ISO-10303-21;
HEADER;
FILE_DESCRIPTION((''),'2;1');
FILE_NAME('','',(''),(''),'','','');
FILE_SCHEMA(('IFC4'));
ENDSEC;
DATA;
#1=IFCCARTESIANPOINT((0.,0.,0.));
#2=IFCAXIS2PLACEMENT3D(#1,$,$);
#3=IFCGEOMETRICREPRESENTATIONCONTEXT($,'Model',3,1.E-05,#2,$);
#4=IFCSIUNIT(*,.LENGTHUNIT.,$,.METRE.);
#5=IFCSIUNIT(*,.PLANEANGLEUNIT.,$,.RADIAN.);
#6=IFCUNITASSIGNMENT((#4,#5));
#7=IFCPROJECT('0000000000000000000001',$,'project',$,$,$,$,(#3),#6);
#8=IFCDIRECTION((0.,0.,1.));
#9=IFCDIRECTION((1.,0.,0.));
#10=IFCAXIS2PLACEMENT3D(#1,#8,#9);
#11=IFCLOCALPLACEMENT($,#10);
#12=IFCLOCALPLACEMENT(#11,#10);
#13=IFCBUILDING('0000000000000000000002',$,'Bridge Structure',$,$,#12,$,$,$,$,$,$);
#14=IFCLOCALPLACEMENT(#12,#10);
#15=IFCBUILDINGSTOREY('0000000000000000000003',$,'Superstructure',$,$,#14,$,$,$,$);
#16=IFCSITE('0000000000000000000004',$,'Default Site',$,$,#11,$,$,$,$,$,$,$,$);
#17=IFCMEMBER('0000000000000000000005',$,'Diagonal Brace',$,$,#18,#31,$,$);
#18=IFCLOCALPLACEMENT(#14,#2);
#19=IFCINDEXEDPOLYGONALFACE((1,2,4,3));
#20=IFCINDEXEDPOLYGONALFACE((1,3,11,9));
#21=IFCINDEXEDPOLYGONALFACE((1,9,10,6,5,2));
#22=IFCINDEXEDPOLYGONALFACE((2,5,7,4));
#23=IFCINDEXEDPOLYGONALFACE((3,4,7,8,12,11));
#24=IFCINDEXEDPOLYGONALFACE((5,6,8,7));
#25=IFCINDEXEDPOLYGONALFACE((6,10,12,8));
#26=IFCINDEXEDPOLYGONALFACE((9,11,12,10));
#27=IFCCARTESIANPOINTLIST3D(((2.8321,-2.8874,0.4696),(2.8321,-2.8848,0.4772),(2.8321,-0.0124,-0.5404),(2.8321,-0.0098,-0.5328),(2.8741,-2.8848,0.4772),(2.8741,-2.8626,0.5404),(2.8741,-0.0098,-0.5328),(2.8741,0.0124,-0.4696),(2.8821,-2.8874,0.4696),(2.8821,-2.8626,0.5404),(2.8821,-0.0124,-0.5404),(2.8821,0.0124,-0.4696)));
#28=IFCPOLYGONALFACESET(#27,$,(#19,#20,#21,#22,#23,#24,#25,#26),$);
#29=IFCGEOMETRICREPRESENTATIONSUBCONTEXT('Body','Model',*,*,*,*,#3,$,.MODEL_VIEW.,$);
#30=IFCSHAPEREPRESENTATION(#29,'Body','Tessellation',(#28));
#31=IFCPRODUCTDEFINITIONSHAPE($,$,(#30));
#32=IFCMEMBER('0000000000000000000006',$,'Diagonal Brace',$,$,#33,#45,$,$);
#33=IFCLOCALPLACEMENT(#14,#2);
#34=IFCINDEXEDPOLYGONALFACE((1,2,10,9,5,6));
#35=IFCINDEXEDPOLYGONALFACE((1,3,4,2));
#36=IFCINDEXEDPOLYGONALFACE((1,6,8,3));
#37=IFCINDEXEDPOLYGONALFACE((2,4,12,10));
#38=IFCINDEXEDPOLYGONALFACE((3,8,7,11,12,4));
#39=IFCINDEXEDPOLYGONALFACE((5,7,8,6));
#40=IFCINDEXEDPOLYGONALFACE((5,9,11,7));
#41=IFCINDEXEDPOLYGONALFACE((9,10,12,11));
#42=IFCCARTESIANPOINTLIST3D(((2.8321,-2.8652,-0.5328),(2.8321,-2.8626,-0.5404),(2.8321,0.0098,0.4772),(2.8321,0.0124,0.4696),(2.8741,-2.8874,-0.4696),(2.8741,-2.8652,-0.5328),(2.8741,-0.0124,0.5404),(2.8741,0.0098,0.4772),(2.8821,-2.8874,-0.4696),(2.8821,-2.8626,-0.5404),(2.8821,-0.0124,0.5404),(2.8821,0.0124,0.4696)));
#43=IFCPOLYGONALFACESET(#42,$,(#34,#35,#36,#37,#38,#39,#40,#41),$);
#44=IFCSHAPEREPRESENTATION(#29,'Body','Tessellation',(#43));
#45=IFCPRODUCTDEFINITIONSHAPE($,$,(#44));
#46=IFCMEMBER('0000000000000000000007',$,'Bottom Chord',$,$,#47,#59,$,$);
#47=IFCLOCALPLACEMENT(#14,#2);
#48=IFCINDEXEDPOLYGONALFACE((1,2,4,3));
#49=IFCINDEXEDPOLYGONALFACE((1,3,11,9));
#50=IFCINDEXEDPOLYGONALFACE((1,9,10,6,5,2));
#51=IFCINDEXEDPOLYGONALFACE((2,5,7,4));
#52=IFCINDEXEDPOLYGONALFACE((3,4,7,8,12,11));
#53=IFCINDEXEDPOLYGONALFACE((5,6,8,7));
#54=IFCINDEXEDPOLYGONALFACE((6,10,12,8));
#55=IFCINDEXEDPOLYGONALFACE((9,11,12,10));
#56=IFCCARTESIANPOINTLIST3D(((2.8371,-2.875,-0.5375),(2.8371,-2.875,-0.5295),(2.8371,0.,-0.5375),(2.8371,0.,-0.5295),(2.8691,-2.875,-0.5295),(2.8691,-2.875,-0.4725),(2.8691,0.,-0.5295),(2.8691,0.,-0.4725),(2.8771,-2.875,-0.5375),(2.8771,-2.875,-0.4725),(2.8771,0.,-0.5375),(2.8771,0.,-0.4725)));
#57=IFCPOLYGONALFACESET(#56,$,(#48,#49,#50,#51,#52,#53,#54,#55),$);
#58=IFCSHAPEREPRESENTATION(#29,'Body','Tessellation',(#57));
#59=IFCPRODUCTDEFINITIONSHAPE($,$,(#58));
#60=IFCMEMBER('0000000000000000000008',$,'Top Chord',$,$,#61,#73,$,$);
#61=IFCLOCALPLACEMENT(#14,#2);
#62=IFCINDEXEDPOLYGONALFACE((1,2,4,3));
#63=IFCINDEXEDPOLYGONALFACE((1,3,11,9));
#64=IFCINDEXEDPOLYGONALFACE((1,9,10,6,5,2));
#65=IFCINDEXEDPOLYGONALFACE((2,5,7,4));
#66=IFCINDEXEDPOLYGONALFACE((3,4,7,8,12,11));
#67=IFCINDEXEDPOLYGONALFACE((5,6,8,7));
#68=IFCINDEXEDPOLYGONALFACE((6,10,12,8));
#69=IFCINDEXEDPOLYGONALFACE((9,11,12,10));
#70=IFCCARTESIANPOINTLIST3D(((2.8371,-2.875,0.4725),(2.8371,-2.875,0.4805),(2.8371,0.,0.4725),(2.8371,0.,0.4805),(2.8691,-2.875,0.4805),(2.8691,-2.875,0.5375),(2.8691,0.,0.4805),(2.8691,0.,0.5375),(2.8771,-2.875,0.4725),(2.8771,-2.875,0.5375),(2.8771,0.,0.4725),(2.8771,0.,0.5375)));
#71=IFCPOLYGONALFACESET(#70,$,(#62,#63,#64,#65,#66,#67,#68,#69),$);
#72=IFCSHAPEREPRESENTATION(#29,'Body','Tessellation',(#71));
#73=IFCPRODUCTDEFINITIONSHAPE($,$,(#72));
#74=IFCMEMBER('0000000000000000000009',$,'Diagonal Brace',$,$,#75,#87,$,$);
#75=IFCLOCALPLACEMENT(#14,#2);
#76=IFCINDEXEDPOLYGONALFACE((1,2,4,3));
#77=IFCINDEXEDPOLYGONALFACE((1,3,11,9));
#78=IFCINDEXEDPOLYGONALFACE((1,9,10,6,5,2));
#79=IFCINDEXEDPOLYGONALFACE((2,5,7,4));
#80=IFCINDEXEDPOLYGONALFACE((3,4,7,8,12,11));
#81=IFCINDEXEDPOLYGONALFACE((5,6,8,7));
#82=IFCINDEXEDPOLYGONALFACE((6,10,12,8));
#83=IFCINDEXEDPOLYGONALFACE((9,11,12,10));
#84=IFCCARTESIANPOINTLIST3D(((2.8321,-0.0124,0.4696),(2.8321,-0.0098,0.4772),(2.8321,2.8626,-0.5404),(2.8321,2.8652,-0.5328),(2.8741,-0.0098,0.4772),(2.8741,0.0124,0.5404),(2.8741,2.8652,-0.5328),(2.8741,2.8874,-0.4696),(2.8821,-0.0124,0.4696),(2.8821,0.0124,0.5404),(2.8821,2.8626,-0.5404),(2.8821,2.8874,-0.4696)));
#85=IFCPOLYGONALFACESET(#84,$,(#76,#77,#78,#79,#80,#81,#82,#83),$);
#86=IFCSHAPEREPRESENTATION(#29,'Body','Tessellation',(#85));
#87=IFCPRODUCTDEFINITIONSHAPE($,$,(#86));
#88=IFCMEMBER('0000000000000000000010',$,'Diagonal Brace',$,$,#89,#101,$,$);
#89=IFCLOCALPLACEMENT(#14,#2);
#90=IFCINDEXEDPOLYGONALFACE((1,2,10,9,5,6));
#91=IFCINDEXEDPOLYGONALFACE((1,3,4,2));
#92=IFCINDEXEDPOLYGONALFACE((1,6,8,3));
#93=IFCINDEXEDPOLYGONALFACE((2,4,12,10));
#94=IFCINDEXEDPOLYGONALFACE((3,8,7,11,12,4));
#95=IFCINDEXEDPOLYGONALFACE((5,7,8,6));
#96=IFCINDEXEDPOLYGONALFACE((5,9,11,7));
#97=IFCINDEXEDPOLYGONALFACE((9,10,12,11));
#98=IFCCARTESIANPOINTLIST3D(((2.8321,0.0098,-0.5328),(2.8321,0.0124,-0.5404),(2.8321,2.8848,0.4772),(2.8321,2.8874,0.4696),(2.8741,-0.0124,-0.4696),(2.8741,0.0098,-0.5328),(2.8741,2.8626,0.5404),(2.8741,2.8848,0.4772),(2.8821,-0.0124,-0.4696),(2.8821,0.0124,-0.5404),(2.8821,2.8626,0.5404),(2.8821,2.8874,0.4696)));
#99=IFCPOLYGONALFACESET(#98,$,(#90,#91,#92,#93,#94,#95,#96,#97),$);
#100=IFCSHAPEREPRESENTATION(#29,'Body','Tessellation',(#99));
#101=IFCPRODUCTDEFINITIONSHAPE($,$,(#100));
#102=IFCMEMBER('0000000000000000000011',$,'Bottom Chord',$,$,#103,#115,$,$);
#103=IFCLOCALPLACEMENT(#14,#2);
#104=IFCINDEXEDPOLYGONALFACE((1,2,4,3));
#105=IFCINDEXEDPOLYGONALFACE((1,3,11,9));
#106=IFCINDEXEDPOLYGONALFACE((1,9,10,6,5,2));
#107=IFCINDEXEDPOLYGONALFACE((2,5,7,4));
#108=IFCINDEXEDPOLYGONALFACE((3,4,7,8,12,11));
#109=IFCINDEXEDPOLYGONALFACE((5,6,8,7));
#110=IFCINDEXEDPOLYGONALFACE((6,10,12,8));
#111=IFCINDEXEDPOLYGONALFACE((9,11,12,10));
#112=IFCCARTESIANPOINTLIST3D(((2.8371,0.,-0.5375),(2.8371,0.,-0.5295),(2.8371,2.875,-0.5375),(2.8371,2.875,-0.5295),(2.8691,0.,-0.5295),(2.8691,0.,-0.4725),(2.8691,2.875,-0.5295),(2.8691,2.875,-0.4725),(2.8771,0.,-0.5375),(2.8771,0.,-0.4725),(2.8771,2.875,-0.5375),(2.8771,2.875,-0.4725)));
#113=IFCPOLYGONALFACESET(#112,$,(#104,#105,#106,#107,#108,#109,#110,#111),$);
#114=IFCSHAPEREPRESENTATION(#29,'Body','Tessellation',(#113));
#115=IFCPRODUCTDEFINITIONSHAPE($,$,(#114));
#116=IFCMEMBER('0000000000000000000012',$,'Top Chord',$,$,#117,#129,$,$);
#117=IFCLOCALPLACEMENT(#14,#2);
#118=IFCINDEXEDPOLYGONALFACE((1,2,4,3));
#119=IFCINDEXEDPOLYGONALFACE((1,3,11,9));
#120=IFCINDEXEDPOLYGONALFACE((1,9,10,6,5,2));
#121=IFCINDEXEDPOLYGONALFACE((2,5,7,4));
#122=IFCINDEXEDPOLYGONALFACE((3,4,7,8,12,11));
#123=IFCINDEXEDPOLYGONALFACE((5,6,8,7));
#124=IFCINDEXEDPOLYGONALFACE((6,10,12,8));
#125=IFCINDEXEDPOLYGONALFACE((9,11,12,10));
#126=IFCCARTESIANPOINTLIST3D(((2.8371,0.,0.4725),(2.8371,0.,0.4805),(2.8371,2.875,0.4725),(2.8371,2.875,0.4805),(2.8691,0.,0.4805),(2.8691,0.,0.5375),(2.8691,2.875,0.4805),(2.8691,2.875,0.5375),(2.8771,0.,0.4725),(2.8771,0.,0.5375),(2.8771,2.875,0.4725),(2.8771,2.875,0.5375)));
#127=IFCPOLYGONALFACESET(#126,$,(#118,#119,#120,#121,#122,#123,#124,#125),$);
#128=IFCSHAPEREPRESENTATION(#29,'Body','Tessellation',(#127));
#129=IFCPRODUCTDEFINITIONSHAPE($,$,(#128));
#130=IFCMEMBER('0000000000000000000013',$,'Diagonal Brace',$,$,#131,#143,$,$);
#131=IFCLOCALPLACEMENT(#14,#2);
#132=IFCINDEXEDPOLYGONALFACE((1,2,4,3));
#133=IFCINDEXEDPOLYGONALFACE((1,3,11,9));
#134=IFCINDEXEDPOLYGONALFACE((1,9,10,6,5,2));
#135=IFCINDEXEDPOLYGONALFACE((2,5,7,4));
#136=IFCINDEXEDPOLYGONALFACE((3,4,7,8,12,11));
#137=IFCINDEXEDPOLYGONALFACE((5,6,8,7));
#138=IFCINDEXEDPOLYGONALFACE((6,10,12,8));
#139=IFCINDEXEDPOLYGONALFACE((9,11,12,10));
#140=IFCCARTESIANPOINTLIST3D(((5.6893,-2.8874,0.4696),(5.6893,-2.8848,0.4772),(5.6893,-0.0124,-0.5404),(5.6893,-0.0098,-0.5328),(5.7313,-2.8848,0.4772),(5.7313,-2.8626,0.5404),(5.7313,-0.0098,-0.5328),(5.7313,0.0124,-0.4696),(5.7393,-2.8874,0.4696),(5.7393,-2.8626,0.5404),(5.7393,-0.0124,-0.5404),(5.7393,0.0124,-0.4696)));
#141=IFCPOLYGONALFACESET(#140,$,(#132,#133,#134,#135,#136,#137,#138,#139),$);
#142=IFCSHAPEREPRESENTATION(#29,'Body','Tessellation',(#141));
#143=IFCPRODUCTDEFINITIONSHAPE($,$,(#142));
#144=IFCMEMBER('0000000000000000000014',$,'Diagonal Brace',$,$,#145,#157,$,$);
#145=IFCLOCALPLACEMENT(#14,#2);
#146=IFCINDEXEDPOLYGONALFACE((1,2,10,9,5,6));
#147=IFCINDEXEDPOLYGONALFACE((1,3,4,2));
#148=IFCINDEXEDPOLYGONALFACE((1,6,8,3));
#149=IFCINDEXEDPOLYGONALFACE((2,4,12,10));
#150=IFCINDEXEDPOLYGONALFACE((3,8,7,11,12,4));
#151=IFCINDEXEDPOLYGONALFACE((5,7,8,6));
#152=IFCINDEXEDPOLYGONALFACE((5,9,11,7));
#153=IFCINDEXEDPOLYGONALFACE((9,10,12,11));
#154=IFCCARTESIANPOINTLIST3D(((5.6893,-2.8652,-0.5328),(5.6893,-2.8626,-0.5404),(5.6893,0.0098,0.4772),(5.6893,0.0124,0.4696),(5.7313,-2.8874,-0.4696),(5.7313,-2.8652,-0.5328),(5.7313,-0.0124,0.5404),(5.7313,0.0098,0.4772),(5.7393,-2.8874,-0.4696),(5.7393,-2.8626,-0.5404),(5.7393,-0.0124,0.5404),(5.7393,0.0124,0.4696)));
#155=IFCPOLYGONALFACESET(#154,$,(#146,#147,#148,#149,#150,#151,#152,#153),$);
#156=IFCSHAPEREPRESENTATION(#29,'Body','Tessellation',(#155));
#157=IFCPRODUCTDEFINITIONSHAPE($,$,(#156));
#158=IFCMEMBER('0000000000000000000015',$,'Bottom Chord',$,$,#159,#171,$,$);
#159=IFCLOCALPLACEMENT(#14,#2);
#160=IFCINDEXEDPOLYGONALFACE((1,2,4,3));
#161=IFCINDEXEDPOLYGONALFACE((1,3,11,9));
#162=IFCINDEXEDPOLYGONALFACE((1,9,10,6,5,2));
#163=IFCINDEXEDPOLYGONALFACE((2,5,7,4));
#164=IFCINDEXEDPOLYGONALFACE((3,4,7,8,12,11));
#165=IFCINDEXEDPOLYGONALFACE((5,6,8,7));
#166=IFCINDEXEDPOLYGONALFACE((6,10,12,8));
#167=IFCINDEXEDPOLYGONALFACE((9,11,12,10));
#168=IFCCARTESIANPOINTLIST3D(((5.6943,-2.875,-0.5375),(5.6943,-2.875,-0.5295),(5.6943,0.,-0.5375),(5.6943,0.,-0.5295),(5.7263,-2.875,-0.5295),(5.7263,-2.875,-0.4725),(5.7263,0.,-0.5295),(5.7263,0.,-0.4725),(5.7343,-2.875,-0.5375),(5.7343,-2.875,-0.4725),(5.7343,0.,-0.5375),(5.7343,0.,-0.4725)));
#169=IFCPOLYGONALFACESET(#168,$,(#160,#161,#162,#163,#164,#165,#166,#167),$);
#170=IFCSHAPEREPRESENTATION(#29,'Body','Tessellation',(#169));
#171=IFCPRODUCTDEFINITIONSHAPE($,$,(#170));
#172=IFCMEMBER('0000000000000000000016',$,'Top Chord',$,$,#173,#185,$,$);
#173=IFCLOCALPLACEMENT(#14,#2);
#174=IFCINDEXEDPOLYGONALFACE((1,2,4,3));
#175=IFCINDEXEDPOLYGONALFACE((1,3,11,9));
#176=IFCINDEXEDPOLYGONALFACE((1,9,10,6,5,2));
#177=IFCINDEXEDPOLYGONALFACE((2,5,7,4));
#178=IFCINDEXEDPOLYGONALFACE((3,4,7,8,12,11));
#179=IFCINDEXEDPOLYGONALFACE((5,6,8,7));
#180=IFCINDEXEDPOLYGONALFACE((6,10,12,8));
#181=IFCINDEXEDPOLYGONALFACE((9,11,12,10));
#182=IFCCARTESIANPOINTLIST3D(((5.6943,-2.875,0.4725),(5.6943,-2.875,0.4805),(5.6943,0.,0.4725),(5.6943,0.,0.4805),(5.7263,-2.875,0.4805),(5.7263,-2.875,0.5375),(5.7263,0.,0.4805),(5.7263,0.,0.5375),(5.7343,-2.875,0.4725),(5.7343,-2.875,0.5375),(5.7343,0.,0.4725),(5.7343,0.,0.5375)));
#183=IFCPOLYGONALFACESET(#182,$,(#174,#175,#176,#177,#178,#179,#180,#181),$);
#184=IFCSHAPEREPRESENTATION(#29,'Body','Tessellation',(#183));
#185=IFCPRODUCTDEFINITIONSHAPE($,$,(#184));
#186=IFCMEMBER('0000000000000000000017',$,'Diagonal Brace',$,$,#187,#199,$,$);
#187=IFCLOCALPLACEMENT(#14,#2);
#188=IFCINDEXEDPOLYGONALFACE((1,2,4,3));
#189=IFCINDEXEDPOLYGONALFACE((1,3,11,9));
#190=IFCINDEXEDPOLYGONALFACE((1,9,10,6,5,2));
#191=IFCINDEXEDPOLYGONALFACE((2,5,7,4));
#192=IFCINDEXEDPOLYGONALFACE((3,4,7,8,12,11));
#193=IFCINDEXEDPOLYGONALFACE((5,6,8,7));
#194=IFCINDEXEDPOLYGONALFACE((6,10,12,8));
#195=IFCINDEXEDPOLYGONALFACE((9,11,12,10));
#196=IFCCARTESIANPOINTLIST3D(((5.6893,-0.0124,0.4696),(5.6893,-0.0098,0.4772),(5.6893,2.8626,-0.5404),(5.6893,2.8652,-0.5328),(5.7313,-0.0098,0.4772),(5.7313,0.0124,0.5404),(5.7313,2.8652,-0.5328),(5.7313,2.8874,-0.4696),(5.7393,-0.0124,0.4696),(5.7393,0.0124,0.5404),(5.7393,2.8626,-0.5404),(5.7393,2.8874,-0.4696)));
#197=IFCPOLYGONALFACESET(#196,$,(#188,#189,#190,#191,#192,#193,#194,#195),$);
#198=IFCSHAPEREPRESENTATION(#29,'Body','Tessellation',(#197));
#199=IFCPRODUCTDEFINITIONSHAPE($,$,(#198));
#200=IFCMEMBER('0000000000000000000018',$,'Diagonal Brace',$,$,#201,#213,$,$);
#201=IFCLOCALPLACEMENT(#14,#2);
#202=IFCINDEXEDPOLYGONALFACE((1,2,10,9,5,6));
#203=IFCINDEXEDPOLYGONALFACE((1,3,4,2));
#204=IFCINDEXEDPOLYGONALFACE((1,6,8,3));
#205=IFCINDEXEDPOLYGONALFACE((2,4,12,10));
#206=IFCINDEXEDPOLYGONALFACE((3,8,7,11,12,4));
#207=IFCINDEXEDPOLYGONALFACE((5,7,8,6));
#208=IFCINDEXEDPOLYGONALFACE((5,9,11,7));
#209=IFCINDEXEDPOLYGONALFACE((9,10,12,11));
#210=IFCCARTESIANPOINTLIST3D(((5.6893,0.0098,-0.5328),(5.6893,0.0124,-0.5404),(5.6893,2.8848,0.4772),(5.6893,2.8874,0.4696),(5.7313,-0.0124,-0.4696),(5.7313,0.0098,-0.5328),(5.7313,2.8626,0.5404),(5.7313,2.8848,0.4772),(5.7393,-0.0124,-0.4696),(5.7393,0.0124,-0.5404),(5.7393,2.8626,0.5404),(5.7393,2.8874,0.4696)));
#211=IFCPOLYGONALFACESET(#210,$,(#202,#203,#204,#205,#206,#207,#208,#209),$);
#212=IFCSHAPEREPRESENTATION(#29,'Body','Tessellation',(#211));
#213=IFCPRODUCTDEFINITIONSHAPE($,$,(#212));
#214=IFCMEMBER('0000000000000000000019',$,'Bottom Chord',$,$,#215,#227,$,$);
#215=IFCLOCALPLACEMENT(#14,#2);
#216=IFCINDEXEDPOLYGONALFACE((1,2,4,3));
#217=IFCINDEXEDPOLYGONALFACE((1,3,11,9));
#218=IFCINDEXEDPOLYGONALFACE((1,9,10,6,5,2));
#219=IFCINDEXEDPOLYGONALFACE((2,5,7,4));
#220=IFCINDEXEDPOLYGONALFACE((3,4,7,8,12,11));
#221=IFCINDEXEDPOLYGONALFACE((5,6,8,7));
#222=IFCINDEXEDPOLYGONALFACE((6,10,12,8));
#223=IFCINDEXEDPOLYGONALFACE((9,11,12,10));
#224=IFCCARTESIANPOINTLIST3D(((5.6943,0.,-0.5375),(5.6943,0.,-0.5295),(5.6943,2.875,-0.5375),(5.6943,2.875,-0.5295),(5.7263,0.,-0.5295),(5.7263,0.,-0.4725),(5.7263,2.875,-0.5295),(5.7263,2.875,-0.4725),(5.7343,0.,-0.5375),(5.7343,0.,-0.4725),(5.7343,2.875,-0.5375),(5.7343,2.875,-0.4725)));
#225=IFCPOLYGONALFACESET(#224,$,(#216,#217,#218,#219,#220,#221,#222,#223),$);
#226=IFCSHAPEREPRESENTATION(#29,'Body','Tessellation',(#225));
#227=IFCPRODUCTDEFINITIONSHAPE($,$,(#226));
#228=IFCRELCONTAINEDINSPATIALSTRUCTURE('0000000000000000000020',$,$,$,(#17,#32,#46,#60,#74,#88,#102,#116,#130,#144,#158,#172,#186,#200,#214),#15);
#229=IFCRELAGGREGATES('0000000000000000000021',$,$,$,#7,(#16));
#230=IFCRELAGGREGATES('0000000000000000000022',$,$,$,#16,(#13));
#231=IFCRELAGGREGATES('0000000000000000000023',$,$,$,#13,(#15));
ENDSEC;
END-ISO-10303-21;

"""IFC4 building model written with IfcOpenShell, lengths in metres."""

from ifc_helpers import new_model, si_unit, frame, origin, origin_with_axes, origin_2d_with_axis, place, context, subcontext, project, spatial, l_section, extrude, element, save


model = new_model("IFC4")

# Units and contexts
model_context = context("Model", 3, precision=1e-05, world=origin())
body_context = subcontext(model_context, "Body", "Model", "MODEL_VIEW")
ifc_project = project(units=[si_unit("LENGTHUNIT", "METRE"), si_unit("PLANEANGLEUNIT", "RADIAN")], contexts=[model_context])

# Site, building, storey
site_placement = place(None, origin_with_axes())
site = spatial("IfcSite", under=ifc_project, at=site_placement, Name="Default Site")
building_placement = place(site_placement, origin_with_axes())
building = spatial("IfcBuilding", under=site, at=building_placement, Name="Bridge Structure")
storey_placement = place(building_placement, origin_with_axes())
storey = spatial("IfcBuildingStorey", under=building, at=storey_placement, Name="Superstructure")

# Members
for number, where, z_axis, x_axis, name in (
    (1, (2.8571, -2.875, 0.505), (0.0, 0.943474, -0.331447), (-1.0, 0.0, 0.0), "Diagonal Brace"),
    (2, (2.8571, -2.875, -0.505), (0.0, 0.943474, 0.331447), (-1.0, 0.0, 0.0), "Diagonal Brace"),
):
    element("IfcMember", number, at=place(storey_placement, frame(where, z_axis=z_axis, x_axis=x_axis)), inside=storey, Name=name, context=body_context, shape_type="SweptSolid", body=[
        extrude(l_section(Depth=0.075, Width=0.05, Thickness=0.008, at=origin_2d_with_axis()), origin_with_axes(), (0.0, 0.0, 1.0), 3.0472),
    ])
for number, where, z_axis, x_axis, name in (
    (3, (2.8571, -2.875, -0.505), (0.0, 1.0, 0.0), (-1.0, 0.0, 0.0), "Bottom Chord"),
    (4, (2.8571, -2.875, 0.505), (0.0, 1.0, 0.0), (-1.0, 0.0, 0.0), "Top Chord"),
):
    element("IfcMember", number, at=place(storey_placement, frame(where, z_axis=z_axis, x_axis=x_axis)), inside=storey, Name=name, context=body_context, shape_type="SweptSolid", body=[
        extrude(l_section(Depth=0.065, Width=0.04, Thickness=0.008, at=origin_2d_with_axis()), origin_with_axes(), (0.0, 0.0, 1.0), 2.875),
    ])
for number, where, z_axis, x_axis, name in (
    (5, (2.8571, 0.0, 0.505), (0.0, 0.943474, -0.331447), (-1.0, 0.0, 0.0), "Diagonal Brace"),
    (6, (2.8571, 0.0, -0.505), (0.0, 0.943474, 0.331447), (-1.0, 0.0, 0.0), "Diagonal Brace"),
):
    element("IfcMember", number, at=place(storey_placement, frame(where, z_axis=z_axis, x_axis=x_axis)), inside=storey, Name=name, context=body_context, shape_type="SweptSolid", body=[
        extrude(l_section(Depth=0.075, Width=0.05, Thickness=0.008, at=origin_2d_with_axis()), origin_with_axes(), (0.0, 0.0, 1.0), 3.0472),
    ])
for number, where, z_axis, x_axis, name in (
    (7, (2.8571, 0.0, -0.505), (0.0, 1.0, 0.0), (-1.0, 0.0, 0.0), "Bottom Chord"),
    (8, (2.8571, 0.0, 0.505), (0.0, 1.0, 0.0), (-1.0, 0.0, 0.0), "Top Chord"),
):
    element("IfcMember", number, at=place(storey_placement, frame(where, z_axis=z_axis, x_axis=x_axis)), inside=storey, Name=name, context=body_context, shape_type="SweptSolid", body=[
        extrude(l_section(Depth=0.065, Width=0.04, Thickness=0.008, at=origin_2d_with_axis()), origin_with_axes(), (0.0, 0.0, 1.0), 2.875),
    ])
for number, where, z_axis, x_axis, name in (
    (9, (5.7143, -2.875, 0.505), (0.0, 0.943474, -0.331447), (-1.0, 0.0, 0.0), "Diagonal Brace"),
    (10, (5.7143, -2.875, -0.505), (0.0, 0.943474, 0.331447), (-1.0, 0.0, 0.0), "Diagonal Brace"),
):
    element("IfcMember", number, at=place(storey_placement, frame(where, z_axis=z_axis, x_axis=x_axis)), inside=storey, Name=name, context=body_context, shape_type="SweptSolid", body=[
        extrude(l_section(Depth=0.075, Width=0.05, Thickness=0.008, at=origin_2d_with_axis()), origin_with_axes(), (0.0, 0.0, 1.0), 3.0472),
    ])
for number, where, z_axis, x_axis, name in (
    (11, (5.7143, -2.875, -0.505), (0.0, 1.0, 0.0), (-1.0, 0.0, 0.0), "Bottom Chord"),
    (12, (5.7143, -2.875, 0.505), (0.0, 1.0, 0.0), (-1.0, 0.0, 0.0), "Top Chord"),
):
    element("IfcMember", number, at=place(storey_placement, frame(where, z_axis=z_axis, x_axis=x_axis)), inside=storey, Name=name, context=body_context, shape_type="SweptSolid", body=[
        extrude(l_section(Depth=0.065, Width=0.04, Thickness=0.008, at=origin_2d_with_axis()), origin_with_axes(), (0.0, 0.0, 1.0), 2.875),
    ])
for number, where, z_axis, x_axis, name in (
    (13, (5.7143, 0.0, 0.505), (0.0, 0.943474, -0.331447), (-1.0, 0.0, 0.0), "Diagonal Brace"),
    (14, (5.7143, 0.0, -0.505), (0.0, 0.943474, 0.331447), (-1.0, 0.0, 0.0), "Diagonal Brace"),
):
    element("IfcMember", number, at=place(storey_placement, frame(where, z_axis=z_axis, x_axis=x_axis)), inside=storey, Name=name, context=body_context, shape_type="SweptSolid", body=[
        extrude(l_section(Depth=0.075, Width=0.05, Thickness=0.008, at=origin_2d_with_axis()), origin_with_axes(), (0.0, 0.0, 1.0), 3.0472),
    ])
for number, where, z_axis, x_axis, name in (
    (15, (5.7143, 0.0, -0.505), (0.0, 1.0, 0.0), (-1.0, 0.0, 0.0), "Bottom Chord"),
):
    element("IfcMember", number, at=place(storey_placement, frame(where, z_axis=z_axis, x_axis=x_axis)), inside=storey, Name=name, context=body_context, shape_type="SweptSolid", body=[
        extrude(l_section(Depth=0.065, Width=0.04, Thickness=0.008, at=origin_2d_with_axis()), origin_with_axes(), (0.0, 0.0, 1.0), 2.875),
    ])

save(model, "model.ifc")
